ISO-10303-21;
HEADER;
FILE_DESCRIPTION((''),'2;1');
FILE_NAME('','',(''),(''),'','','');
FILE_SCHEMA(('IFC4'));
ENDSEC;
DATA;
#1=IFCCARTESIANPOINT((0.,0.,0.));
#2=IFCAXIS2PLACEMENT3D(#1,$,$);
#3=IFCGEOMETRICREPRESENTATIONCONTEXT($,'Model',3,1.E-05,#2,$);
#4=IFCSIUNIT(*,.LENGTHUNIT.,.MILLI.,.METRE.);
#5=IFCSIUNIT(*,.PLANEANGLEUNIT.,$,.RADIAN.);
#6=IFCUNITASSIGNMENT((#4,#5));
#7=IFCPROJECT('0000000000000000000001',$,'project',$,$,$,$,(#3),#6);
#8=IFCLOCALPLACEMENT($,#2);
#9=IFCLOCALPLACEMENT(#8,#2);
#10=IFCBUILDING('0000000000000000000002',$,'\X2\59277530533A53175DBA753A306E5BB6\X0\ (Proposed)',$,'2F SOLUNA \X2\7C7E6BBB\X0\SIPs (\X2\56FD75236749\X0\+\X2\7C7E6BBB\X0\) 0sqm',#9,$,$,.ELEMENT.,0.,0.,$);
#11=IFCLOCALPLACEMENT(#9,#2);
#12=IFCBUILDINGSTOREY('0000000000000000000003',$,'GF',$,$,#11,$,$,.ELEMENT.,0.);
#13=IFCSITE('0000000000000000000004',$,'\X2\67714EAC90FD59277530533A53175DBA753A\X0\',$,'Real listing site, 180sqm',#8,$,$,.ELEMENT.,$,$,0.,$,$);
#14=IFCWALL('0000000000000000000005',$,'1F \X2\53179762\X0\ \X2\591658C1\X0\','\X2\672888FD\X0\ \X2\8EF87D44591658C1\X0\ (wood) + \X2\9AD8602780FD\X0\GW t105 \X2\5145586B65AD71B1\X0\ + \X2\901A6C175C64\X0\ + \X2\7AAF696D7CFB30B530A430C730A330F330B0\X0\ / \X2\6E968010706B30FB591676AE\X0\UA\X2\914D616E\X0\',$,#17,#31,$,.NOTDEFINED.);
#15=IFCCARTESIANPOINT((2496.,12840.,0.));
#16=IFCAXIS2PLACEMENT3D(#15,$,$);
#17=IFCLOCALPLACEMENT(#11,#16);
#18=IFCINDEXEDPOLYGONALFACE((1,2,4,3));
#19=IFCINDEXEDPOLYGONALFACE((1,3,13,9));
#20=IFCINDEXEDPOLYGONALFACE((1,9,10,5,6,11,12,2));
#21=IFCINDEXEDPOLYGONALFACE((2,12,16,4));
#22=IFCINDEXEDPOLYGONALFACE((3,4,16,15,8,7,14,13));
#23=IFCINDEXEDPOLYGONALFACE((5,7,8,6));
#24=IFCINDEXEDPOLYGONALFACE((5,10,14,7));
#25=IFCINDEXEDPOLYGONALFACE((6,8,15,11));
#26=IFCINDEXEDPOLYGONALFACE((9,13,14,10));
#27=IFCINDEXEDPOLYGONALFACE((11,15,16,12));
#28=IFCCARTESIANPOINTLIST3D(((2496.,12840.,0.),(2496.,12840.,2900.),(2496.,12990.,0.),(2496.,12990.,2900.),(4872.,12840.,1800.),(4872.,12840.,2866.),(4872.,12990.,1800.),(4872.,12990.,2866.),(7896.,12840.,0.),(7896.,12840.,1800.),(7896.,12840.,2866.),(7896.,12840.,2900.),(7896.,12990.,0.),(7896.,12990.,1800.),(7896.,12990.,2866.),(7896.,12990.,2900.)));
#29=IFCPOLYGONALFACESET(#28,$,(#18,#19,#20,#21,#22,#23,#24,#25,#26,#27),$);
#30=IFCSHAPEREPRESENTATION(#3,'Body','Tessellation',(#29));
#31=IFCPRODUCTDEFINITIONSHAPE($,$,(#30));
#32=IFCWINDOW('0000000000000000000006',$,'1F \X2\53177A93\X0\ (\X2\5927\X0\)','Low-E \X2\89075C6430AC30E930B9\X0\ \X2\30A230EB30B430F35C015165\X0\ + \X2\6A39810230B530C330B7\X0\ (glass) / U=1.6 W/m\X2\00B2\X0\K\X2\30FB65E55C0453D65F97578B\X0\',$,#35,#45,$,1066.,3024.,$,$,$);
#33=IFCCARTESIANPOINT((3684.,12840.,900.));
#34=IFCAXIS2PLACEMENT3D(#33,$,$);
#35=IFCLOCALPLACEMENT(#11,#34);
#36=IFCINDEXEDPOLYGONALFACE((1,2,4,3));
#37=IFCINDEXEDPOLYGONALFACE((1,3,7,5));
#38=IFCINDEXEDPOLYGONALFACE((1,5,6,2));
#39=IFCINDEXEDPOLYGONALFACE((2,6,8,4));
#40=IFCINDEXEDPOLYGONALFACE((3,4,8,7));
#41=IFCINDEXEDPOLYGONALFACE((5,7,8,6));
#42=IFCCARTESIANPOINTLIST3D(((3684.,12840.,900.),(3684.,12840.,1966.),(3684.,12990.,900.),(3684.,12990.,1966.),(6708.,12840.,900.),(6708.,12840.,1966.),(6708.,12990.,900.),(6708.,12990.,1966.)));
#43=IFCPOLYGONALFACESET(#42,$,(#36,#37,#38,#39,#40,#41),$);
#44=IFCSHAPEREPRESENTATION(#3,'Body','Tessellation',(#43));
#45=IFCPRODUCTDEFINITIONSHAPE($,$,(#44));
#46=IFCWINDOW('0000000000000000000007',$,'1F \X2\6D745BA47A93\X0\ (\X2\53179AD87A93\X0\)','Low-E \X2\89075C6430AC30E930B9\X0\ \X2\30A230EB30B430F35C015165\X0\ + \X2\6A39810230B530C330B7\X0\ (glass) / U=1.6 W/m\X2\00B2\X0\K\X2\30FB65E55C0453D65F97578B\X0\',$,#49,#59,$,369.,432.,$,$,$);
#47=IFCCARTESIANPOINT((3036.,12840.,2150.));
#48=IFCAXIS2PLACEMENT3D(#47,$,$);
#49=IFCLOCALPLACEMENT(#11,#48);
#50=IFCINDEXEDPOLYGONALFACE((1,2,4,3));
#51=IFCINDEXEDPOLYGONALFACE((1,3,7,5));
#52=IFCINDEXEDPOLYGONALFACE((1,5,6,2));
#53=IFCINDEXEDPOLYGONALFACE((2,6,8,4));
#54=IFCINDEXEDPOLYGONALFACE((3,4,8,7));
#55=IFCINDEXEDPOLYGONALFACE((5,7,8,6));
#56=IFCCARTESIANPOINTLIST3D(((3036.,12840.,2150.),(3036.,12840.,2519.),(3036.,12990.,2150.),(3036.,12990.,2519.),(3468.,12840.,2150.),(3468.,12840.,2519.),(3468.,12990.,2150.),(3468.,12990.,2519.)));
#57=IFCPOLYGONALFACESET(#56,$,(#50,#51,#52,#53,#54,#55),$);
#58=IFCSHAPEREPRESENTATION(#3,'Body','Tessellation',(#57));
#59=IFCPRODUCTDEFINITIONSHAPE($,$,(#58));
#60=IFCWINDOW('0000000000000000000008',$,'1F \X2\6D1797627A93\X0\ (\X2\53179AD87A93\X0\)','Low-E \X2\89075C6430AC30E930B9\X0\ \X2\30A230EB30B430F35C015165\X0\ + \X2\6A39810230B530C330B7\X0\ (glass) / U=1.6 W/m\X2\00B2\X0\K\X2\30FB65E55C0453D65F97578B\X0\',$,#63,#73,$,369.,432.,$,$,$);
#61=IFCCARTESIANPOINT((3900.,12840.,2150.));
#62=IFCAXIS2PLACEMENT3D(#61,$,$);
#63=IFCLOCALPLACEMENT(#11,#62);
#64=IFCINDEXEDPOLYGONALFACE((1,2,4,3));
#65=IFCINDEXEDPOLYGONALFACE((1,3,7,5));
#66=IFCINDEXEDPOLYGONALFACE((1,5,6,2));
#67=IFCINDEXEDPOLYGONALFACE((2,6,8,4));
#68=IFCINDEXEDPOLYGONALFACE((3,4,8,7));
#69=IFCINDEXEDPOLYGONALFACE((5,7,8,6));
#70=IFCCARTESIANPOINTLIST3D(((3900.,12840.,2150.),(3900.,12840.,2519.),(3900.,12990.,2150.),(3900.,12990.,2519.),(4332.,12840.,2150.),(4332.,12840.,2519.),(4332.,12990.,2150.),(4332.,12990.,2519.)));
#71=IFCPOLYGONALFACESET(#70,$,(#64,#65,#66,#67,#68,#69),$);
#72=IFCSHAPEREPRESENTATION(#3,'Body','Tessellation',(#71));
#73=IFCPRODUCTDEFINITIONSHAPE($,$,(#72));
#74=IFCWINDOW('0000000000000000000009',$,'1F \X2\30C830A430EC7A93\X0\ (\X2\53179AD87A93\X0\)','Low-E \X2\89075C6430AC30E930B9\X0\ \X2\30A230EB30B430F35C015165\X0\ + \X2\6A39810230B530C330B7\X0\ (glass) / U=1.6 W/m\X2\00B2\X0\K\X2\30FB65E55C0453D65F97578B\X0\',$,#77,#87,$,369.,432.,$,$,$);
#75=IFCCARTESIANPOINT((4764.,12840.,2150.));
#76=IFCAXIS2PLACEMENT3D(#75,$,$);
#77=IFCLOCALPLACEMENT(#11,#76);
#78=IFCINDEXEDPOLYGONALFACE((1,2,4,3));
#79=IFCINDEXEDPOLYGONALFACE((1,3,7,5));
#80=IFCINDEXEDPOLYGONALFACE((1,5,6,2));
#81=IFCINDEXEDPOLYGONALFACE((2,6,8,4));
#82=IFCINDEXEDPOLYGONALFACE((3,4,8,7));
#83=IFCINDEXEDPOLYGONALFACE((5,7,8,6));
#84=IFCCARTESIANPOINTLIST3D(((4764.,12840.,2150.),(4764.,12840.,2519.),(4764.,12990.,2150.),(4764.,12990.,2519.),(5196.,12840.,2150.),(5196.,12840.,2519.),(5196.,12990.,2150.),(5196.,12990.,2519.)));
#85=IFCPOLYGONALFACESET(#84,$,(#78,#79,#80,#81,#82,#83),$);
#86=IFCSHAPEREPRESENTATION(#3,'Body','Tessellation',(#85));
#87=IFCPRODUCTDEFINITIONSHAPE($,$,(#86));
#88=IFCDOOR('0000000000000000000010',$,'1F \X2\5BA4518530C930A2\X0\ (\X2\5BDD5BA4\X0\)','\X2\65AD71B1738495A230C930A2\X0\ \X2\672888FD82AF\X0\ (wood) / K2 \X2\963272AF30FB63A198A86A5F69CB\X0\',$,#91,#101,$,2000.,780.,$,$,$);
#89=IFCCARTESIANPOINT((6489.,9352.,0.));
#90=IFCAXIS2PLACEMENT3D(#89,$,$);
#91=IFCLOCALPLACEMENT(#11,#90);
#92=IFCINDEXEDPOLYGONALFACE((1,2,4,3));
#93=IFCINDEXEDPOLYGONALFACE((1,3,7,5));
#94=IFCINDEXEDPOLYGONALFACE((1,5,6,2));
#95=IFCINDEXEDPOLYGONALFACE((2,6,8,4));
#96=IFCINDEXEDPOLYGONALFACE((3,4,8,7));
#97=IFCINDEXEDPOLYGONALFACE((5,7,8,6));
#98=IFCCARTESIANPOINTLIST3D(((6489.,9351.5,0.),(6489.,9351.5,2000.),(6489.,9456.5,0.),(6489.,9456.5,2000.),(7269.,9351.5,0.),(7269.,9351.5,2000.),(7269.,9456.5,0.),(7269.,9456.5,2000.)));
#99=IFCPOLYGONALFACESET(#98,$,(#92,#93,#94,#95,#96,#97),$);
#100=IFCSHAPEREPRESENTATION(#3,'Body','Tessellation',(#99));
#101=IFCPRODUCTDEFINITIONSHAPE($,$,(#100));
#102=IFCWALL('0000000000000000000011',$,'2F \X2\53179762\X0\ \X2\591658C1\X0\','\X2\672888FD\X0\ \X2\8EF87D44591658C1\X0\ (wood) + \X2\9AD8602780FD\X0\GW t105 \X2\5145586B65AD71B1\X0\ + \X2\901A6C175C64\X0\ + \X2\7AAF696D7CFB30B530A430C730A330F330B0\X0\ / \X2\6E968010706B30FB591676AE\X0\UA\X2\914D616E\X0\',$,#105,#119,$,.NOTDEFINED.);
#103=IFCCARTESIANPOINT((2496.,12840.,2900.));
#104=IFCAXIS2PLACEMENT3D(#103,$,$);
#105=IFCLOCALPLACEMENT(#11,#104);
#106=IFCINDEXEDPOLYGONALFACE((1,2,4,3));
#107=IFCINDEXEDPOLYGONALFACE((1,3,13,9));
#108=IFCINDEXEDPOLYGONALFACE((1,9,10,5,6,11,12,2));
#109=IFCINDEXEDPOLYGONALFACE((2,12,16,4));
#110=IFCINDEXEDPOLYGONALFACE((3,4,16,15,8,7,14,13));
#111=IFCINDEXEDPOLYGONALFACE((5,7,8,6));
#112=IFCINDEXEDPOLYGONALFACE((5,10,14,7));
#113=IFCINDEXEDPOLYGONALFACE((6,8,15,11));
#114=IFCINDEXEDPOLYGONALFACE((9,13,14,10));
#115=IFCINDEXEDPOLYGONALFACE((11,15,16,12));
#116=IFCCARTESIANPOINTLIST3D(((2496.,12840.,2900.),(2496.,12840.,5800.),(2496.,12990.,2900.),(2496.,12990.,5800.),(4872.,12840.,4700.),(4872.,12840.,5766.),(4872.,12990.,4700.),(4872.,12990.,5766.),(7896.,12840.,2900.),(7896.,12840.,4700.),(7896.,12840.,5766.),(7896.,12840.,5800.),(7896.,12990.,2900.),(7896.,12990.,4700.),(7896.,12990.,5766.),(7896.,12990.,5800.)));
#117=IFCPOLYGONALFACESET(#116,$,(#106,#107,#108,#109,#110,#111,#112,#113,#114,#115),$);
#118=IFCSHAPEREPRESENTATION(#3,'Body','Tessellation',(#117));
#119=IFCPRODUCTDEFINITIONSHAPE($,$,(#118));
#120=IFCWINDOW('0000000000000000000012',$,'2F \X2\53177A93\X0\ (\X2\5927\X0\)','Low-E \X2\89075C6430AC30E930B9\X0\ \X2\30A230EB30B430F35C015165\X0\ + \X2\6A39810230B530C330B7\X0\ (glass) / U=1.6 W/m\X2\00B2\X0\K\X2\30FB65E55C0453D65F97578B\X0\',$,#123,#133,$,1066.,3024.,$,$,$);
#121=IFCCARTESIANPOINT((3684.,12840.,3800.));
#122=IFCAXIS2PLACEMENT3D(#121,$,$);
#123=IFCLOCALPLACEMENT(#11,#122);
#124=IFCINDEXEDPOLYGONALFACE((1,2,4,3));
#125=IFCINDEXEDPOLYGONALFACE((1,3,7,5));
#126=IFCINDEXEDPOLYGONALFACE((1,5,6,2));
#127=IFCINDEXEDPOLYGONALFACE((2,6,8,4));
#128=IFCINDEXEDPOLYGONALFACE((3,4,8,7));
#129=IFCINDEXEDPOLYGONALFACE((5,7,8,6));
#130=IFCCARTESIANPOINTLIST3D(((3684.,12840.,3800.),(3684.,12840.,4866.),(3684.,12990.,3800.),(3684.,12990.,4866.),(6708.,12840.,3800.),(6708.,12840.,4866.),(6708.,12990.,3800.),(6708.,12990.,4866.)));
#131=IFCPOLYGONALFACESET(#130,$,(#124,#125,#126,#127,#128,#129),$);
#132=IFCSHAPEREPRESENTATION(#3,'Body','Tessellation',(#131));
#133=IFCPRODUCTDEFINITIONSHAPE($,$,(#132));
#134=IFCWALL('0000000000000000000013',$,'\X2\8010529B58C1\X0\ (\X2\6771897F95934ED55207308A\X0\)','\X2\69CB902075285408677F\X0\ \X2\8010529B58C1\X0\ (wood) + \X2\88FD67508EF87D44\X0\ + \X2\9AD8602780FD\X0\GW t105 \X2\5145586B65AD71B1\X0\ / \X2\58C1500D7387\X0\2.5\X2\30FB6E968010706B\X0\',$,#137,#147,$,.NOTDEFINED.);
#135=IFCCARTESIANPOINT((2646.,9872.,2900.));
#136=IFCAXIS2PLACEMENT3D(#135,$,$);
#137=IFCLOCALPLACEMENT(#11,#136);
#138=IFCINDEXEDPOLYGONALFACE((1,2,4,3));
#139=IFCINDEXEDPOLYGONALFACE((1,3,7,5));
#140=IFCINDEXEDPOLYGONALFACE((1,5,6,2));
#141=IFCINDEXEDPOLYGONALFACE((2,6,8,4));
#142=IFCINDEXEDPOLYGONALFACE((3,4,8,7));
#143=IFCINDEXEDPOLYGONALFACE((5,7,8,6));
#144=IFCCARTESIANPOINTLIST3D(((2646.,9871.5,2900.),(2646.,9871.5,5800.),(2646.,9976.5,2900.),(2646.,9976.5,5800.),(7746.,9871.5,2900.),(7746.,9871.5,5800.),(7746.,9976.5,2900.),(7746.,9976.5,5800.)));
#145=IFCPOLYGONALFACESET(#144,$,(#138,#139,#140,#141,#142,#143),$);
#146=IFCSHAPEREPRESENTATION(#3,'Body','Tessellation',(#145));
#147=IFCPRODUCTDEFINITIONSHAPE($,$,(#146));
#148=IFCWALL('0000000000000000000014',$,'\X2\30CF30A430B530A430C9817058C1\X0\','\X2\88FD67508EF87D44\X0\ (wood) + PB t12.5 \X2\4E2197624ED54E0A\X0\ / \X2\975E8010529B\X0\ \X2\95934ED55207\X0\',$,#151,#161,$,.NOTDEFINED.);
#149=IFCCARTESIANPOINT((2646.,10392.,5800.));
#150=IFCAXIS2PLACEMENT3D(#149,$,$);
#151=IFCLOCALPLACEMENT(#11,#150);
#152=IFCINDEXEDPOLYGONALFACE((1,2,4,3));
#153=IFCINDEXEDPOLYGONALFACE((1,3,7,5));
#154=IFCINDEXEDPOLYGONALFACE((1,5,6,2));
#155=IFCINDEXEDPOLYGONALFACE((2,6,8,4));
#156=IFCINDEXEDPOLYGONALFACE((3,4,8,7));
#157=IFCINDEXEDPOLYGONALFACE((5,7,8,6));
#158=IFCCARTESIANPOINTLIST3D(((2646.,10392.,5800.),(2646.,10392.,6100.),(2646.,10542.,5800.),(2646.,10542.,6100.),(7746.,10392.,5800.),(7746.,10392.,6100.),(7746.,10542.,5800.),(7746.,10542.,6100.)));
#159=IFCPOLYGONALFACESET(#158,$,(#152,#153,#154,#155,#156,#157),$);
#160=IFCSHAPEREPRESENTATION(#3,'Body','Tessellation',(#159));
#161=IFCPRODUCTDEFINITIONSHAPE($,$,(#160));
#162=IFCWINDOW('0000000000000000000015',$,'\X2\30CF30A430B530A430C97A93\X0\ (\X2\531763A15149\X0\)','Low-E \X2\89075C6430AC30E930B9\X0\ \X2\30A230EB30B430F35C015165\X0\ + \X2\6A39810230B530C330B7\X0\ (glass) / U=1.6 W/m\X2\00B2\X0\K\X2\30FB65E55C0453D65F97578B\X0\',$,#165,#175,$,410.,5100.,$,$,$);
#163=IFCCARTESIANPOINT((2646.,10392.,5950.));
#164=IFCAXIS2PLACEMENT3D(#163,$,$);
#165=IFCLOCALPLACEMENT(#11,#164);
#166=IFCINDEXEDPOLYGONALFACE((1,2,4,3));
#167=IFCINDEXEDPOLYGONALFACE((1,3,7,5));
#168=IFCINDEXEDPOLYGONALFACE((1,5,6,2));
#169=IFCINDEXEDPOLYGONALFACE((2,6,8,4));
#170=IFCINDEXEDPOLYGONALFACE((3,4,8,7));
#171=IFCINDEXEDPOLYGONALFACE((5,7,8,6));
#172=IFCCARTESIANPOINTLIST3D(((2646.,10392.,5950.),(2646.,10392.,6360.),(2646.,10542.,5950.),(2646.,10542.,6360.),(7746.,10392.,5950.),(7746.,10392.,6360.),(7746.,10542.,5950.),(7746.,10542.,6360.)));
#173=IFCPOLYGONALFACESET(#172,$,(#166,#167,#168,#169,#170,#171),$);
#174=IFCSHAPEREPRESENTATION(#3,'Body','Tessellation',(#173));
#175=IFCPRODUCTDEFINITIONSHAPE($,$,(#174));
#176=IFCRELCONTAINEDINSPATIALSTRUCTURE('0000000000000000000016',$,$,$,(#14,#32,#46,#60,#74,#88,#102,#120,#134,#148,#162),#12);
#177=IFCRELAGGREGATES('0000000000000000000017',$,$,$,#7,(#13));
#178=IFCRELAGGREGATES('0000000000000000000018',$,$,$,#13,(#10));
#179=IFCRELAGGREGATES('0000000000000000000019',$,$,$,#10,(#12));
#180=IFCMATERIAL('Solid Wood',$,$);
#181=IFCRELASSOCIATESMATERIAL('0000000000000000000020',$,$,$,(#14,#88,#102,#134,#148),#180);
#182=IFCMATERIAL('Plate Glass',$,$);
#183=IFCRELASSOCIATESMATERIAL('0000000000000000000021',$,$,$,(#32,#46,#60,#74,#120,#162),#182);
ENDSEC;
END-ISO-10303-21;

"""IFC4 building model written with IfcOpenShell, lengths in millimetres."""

from ifc_helpers import new_model, si_unit, frame, frame_2d, origin, place, context, project, spatial, rectangle, extrude, material, element, fill, save


model = new_model("IFC4")

# Units and contexts
model_context = context("Model", 3, precision=1e-05, world=origin())
ifc_project = project(units=[si_unit("LENGTHUNIT", "METRE", prefix="MILLI"), si_unit("PLANEANGLEUNIT", "RADIAN")], contexts=[model_context])

# Site, building, storey
site_placement = place(None, origin())
site = spatial("IfcSite", under=ifc_project, at=site_placement, Name="東京都大田区北嶺町", ObjectType="Real listing site, 180sqm", CompositionType="ELEMENT", RefElevation=0.0)
building_placement = place(site_placement, origin())
building = spatial("IfcBuilding", under=site, at=building_placement, Name="大田区北嶺町の家 (Proposed)", ObjectType="2F SOLUNA 籾殻SIPs (国産杉+籾殻) 0sqm", CompositionType="ELEMENT", ElevationOfRefHeight=0.0, ElevationOfTerrain=0.0)
storey_placement = place(building_placement, origin())
storey = spatial("IfcBuildingStorey", under=building, at=storey_placement, Name="GF", CompositionType="ELEMENT", Elevation=0.0)

# Wall, openings, windows
ifc_material_1 = material(Name="Solid Wood")
wall_1_placement = place(storey_placement, frame((2496.0, 12840.0, 0.0)))
wall_1 = element("IfcWall", 1, at=wall_1_placement, inside=storey, material=ifc_material_1, Name="1F 北面 外壁", Description="木製 軸組外壁 (wood) + 高性能GW t105 充填断熱 + 通気層 + 窯業系サイディング / 準耐火・外皮UA配慮", PredefinedType="NOTDEFINED", context=model_context, shape_type="SweptSolid", body=[
    extrude(rectangle(XDim=5400.0, YDim=150.0, at=frame_2d((2700.0, 75.0))), frame((2496.0, 12840.0, 0.0)), (0.0, 0.0, 1.0), 2900.0),
])
opening_1_placement = place(storey_placement, frame((3684.0, 12840.0, 900.0)))
opening_1 = element("IfcOpeningElement", 2, at=opening_1_placement, cuts=wall_1, PredefinedType="NOTDEFINED", context=model_context, shape_type="SweptSolid", body=[
    extrude(rectangle(XDim=3024.0, YDim=150.0, at=frame_2d((1512.0, 75.0))), frame((3684.0, 12840.0, 900.0)), (0.0, 0.0, 1.0), 1066.0),
])
opening_2_placement = place(storey_placement, frame((3036.0, 12840.0, 2150.0)))
opening_2 = element("IfcOpeningElement", 3, at=opening_2_placement, cuts=wall_1, PredefinedType="NOTDEFINED", context=model_context, shape_type="SweptSolid", body=[
    extrude(rectangle(XDim=432.0, YDim=150.0, at=frame_2d((216.0, 75.0))), frame((3036.0, 12840.0, 2150.0)), (0.0, 0.0, 1.0), 369.0),
])
opening_3_placement = place(storey_placement, frame((3900.0, 12840.0, 2150.0)))
opening_3 = element("IfcOpeningElement", 4, at=opening_3_placement, cuts=wall_1, PredefinedType="NOTDEFINED", context=model_context, shape_type="SweptSolid", body=[
    extrude(rectangle(XDim=432.0, YDim=150.0, at=frame_2d((216.0, 75.0))), frame((3900.0, 12840.0, 2150.0)), (0.0, 0.0, 1.0), 369.0),
])
opening_4_placement = place(storey_placement, frame((4764.0, 12840.0, 2150.0)))
opening_4 = element("IfcOpeningElement", 5, at=opening_4_placement, cuts=wall_1, PredefinedType="NOTDEFINED", context=model_context, shape_type="SweptSolid", body=[
    extrude(rectangle(XDim=432.0, YDim=150.0, at=frame_2d((216.0, 75.0))), frame((4764.0, 12840.0, 2150.0)), (0.0, 0.0, 1.0), 369.0),
])
ifc_material_2 = material(Name="Plate Glass")
window_1_placement = place(storey_placement, frame((3684.0, 12840.0, 900.0)))
window_1 = element("IfcWindow", 6, at=window_1_placement, inside=storey, material=ifc_material_2, Name="1F 北窓 (大)", Description="Low-E 複層ガラス アルゴン封入 + 樹脂サッシ (glass) / U=1.6 W/m²K・日射取得型", OverallHeight=1066.0, OverallWidth=3024.0, context=model_context, shape_type="SweptSolid", body=[
    extrude(rectangle(XDim=3024.0, YDim=150.0, at=frame_2d((1512.0, 75.0))), frame((3684.0, 12840.0, 900.0)), (0.0, 0.0, 1.0), 1066.0),
])
fill(opening_1, window_1)
window_2_placement = place(storey_placement, frame((3036.0, 12840.0, 2150.0)))
window_2 = element("IfcWindow", 7, at=window_2_placement, inside=storey, material=ifc_material_2, Name="1F 浴室窓 (北高窓)", Description="Low-E 複層ガラス アルゴン封入 + 樹脂サッシ (glass) / U=1.6 W/m²K・日射取得型", OverallHeight=369.0, OverallWidth=432.0, context=model_context, shape_type="SweptSolid", body=[
    extrude(rectangle(XDim=432.0, YDim=150.0, at=frame_2d((216.0, 75.0))), frame((3036.0, 12840.0, 2150.0)), (0.0, 0.0, 1.0), 369.0),
])
fill(opening_2, window_2)
window_3_placement = place(storey_placement, frame((3900.0, 12840.0, 2150.0)))
window_3 = element("IfcWindow", 8, at=window_3_placement, inside=storey, material=ifc_material_2, Name="1F 洗面窓 (北高窓)", Description="Low-E 複層ガラス アルゴン封入 + 樹脂サッシ (glass) / U=1.6 W/m²K・日射取得型", OverallHeight=369.0, OverallWidth=432.0, context=model_context, shape_type="SweptSolid", body=[
    extrude(rectangle(XDim=432.0, YDim=150.0, at=frame_2d((216.0, 75.0))), frame((3900.0, 12840.0, 2150.0)), (0.0, 0.0, 1.0), 369.0),
])
fill(opening_3, window_3)
window_4_placement = place(storey_placement, frame((4764.0, 12840.0, 2150.0)))
window_4 = element("IfcWindow", 9, at=window_4_placement, inside=storey, material=ifc_material_2, Name="1F トイレ窓 (北高窓)", Description="Low-E 複層ガラス アルゴン封入 + 樹脂サッシ (glass) / U=1.6 W/m²K・日射取得型", OverallHeight=369.0, OverallWidth=432.0, context=model_context, shape_type="SweptSolid", body=[
    extrude(rectangle(XDim=432.0, YDim=150.0, at=frame_2d((216.0, 75.0))), frame((4764.0, 12840.0, 2150.0)), (0.0, 0.0, 1.0), 369.0),
])
fill(opening_4, window_4)

# Door
door_1_placement = place(storey_placement, frame((6489.0, 9352.0, 0.0)))
element("IfcDoor", 10, at=door_1_placement, inside=storey, material=ifc_material_1, Name="1F 室内ドア (寝室)", Description="断熱玄関ドア 木製芯 (wood) / K2 防犯・採風機構", OverallHeight=2000.0, OverallWidth=780.0, context=model_context, shape_type="SweptSolid", body=[
    extrude(rectangle(XDim=780.0, YDim=105.0, at=frame_2d((390.0, 52.0))), frame((6489.0, 9352.0, 0.0)), (0.0, 0.0, 1.0), 2000.0),
])

# Wall, opening, window
wall_2_placement = place(storey_placement, frame((2496.0, 12840.0, 2900.0)))
wall_2 = element("IfcWall", 11, at=wall_2_placement, inside=storey, material=ifc_material_1, Name="2F 北面 外壁", Description="木製 軸組外壁 (wood) + 高性能GW t105 充填断熱 + 通気層 + 窯業系サイディング / 準耐火・外皮UA配慮", PredefinedType="NOTDEFINED", context=model_context, shape_type="SweptSolid", body=[
    extrude(rectangle(XDim=5400.0, YDim=150.0, at=frame_2d((2700.0, 75.0))), frame((2496.0, 12840.0, 2900.0)), (0.0, 0.0, 1.0), 2900.0),
])
opening_5_placement = place(storey_placement, frame((3684.0, 12840.0, 3800.0)))
opening_5 = element("IfcOpeningElement", 12, at=opening_5_placement, cuts=wall_2, PredefinedType="NOTDEFINED", context=model_context, shape_type="SweptSolid", body=[
    extrude(rectangle(XDim=3024.0, YDim=150.0, at=frame_2d((1512.0, 75.0))), frame((3684.0, 12840.0, 3800.0)), (0.0, 0.0, 1.0), 1066.0),
])
window_5_placement = place(storey_placement, frame((3684.0, 12840.0, 3800.0)))
window_5 = element("IfcWindow", 13, at=window_5_placement, inside=storey, material=ifc_material_2, Name="2F 北窓 (大)", Description="Low-E 複層ガラス アルゴン封入 + 樹脂サッシ (glass) / U=1.6 W/m²K・日射取得型", OverallHeight=1066.0, OverallWidth=3024.0, context=model_context, shape_type="SweptSolid", body=[
    extrude(rectangle(XDim=3024.0, YDim=150.0, at=frame_2d((1512.0, 75.0))), frame((3684.0, 12840.0, 3800.0)), (0.0, 0.0, 1.0), 1066.0),
])
fill(opening_5, window_5)

# Wall
wall_3_placement = place(storey_placement, frame((2646.0, 9872.0, 2900.0)))
element("IfcWall", 14, at=wall_3_placement, inside=storey, material=ifc_material_1, Name="耐力壁 (東西間仕切り)", Description="構造用合板 耐力壁 (wood) + 製材軸組 + 高性能GW t105 充填断熱 / 壁倍率2.5・準耐火", PredefinedType="NOTDEFINED", context=model_context, shape_type="SweptSolid", body=[
    extrude(rectangle(XDim=5100.0, YDim=105.0, at=frame_2d((2550.0, 52.0))), frame((2646.0, 9872.0, 2900.0)), (0.0, 0.0, 1.0), 2900.0),
])

# Wall, opening, window
wall_4_placement = place(storey_placement, frame((2646.0, 10392.0, 5800.0)))
wall_4 = element("IfcWall", 15, at=wall_4_placement, inside=storey, material=ifc_material_1, Name="ハイサイド腰壁", Description="製材軸組 (wood) + PB t12.5 両面仕上 / 非耐力 間仕切", PredefinedType="NOTDEFINED", context=model_context, shape_type="SweptSolid", body=[
    extrude(rectangle(XDim=5100.0, YDim=150.0, at=frame_2d((2550.0, 75.0))), frame((2646.0, 10392.0, 5800.0)), (0.0, 0.0, 1.0), 700.0),
])
opening_6_placement = place(storey_placement, frame((2646.0, 10392.0, 5950.0)))
opening_6 = element("IfcOpeningElement", 16, at=opening_6_placement, cuts=wall_4, PredefinedType="NOTDEFINED", context=model_context, shape_type="SweptSolid", body=[
    extrude(rectangle(XDim=5100.0, YDim=150.0, at=frame_2d((2550.0, 75.0))), frame((2646.0, 10392.0, 5950.0)), (0.0, 0.0, 1.0), 410.0),
])
window_6_placement = place(storey_placement, frame((2646.0, 10392.0, 5950.0)))
window_6 = element("IfcWindow", 17, at=window_6_placement, inside=storey, material=ifc_material_2, Name="ハイサイド窓 (北採光)", Description="Low-E 複層ガラス アルゴン封入 + 樹脂サッシ (glass) / U=1.6 W/m²K・日射取得型", OverallHeight=410.0, OverallWidth=5100.0, context=model_context, shape_type="SweptSolid", body=[
    extrude(rectangle(XDim=5100.0, YDim=150.0, at=frame_2d((2550.0, 75.0))), frame((2646.0, 10392.0, 5950.0)), (0.0, 0.0, 1.0), 410.0),
])
fill(opening_6, window_6)

save(model, "model.ifc")
